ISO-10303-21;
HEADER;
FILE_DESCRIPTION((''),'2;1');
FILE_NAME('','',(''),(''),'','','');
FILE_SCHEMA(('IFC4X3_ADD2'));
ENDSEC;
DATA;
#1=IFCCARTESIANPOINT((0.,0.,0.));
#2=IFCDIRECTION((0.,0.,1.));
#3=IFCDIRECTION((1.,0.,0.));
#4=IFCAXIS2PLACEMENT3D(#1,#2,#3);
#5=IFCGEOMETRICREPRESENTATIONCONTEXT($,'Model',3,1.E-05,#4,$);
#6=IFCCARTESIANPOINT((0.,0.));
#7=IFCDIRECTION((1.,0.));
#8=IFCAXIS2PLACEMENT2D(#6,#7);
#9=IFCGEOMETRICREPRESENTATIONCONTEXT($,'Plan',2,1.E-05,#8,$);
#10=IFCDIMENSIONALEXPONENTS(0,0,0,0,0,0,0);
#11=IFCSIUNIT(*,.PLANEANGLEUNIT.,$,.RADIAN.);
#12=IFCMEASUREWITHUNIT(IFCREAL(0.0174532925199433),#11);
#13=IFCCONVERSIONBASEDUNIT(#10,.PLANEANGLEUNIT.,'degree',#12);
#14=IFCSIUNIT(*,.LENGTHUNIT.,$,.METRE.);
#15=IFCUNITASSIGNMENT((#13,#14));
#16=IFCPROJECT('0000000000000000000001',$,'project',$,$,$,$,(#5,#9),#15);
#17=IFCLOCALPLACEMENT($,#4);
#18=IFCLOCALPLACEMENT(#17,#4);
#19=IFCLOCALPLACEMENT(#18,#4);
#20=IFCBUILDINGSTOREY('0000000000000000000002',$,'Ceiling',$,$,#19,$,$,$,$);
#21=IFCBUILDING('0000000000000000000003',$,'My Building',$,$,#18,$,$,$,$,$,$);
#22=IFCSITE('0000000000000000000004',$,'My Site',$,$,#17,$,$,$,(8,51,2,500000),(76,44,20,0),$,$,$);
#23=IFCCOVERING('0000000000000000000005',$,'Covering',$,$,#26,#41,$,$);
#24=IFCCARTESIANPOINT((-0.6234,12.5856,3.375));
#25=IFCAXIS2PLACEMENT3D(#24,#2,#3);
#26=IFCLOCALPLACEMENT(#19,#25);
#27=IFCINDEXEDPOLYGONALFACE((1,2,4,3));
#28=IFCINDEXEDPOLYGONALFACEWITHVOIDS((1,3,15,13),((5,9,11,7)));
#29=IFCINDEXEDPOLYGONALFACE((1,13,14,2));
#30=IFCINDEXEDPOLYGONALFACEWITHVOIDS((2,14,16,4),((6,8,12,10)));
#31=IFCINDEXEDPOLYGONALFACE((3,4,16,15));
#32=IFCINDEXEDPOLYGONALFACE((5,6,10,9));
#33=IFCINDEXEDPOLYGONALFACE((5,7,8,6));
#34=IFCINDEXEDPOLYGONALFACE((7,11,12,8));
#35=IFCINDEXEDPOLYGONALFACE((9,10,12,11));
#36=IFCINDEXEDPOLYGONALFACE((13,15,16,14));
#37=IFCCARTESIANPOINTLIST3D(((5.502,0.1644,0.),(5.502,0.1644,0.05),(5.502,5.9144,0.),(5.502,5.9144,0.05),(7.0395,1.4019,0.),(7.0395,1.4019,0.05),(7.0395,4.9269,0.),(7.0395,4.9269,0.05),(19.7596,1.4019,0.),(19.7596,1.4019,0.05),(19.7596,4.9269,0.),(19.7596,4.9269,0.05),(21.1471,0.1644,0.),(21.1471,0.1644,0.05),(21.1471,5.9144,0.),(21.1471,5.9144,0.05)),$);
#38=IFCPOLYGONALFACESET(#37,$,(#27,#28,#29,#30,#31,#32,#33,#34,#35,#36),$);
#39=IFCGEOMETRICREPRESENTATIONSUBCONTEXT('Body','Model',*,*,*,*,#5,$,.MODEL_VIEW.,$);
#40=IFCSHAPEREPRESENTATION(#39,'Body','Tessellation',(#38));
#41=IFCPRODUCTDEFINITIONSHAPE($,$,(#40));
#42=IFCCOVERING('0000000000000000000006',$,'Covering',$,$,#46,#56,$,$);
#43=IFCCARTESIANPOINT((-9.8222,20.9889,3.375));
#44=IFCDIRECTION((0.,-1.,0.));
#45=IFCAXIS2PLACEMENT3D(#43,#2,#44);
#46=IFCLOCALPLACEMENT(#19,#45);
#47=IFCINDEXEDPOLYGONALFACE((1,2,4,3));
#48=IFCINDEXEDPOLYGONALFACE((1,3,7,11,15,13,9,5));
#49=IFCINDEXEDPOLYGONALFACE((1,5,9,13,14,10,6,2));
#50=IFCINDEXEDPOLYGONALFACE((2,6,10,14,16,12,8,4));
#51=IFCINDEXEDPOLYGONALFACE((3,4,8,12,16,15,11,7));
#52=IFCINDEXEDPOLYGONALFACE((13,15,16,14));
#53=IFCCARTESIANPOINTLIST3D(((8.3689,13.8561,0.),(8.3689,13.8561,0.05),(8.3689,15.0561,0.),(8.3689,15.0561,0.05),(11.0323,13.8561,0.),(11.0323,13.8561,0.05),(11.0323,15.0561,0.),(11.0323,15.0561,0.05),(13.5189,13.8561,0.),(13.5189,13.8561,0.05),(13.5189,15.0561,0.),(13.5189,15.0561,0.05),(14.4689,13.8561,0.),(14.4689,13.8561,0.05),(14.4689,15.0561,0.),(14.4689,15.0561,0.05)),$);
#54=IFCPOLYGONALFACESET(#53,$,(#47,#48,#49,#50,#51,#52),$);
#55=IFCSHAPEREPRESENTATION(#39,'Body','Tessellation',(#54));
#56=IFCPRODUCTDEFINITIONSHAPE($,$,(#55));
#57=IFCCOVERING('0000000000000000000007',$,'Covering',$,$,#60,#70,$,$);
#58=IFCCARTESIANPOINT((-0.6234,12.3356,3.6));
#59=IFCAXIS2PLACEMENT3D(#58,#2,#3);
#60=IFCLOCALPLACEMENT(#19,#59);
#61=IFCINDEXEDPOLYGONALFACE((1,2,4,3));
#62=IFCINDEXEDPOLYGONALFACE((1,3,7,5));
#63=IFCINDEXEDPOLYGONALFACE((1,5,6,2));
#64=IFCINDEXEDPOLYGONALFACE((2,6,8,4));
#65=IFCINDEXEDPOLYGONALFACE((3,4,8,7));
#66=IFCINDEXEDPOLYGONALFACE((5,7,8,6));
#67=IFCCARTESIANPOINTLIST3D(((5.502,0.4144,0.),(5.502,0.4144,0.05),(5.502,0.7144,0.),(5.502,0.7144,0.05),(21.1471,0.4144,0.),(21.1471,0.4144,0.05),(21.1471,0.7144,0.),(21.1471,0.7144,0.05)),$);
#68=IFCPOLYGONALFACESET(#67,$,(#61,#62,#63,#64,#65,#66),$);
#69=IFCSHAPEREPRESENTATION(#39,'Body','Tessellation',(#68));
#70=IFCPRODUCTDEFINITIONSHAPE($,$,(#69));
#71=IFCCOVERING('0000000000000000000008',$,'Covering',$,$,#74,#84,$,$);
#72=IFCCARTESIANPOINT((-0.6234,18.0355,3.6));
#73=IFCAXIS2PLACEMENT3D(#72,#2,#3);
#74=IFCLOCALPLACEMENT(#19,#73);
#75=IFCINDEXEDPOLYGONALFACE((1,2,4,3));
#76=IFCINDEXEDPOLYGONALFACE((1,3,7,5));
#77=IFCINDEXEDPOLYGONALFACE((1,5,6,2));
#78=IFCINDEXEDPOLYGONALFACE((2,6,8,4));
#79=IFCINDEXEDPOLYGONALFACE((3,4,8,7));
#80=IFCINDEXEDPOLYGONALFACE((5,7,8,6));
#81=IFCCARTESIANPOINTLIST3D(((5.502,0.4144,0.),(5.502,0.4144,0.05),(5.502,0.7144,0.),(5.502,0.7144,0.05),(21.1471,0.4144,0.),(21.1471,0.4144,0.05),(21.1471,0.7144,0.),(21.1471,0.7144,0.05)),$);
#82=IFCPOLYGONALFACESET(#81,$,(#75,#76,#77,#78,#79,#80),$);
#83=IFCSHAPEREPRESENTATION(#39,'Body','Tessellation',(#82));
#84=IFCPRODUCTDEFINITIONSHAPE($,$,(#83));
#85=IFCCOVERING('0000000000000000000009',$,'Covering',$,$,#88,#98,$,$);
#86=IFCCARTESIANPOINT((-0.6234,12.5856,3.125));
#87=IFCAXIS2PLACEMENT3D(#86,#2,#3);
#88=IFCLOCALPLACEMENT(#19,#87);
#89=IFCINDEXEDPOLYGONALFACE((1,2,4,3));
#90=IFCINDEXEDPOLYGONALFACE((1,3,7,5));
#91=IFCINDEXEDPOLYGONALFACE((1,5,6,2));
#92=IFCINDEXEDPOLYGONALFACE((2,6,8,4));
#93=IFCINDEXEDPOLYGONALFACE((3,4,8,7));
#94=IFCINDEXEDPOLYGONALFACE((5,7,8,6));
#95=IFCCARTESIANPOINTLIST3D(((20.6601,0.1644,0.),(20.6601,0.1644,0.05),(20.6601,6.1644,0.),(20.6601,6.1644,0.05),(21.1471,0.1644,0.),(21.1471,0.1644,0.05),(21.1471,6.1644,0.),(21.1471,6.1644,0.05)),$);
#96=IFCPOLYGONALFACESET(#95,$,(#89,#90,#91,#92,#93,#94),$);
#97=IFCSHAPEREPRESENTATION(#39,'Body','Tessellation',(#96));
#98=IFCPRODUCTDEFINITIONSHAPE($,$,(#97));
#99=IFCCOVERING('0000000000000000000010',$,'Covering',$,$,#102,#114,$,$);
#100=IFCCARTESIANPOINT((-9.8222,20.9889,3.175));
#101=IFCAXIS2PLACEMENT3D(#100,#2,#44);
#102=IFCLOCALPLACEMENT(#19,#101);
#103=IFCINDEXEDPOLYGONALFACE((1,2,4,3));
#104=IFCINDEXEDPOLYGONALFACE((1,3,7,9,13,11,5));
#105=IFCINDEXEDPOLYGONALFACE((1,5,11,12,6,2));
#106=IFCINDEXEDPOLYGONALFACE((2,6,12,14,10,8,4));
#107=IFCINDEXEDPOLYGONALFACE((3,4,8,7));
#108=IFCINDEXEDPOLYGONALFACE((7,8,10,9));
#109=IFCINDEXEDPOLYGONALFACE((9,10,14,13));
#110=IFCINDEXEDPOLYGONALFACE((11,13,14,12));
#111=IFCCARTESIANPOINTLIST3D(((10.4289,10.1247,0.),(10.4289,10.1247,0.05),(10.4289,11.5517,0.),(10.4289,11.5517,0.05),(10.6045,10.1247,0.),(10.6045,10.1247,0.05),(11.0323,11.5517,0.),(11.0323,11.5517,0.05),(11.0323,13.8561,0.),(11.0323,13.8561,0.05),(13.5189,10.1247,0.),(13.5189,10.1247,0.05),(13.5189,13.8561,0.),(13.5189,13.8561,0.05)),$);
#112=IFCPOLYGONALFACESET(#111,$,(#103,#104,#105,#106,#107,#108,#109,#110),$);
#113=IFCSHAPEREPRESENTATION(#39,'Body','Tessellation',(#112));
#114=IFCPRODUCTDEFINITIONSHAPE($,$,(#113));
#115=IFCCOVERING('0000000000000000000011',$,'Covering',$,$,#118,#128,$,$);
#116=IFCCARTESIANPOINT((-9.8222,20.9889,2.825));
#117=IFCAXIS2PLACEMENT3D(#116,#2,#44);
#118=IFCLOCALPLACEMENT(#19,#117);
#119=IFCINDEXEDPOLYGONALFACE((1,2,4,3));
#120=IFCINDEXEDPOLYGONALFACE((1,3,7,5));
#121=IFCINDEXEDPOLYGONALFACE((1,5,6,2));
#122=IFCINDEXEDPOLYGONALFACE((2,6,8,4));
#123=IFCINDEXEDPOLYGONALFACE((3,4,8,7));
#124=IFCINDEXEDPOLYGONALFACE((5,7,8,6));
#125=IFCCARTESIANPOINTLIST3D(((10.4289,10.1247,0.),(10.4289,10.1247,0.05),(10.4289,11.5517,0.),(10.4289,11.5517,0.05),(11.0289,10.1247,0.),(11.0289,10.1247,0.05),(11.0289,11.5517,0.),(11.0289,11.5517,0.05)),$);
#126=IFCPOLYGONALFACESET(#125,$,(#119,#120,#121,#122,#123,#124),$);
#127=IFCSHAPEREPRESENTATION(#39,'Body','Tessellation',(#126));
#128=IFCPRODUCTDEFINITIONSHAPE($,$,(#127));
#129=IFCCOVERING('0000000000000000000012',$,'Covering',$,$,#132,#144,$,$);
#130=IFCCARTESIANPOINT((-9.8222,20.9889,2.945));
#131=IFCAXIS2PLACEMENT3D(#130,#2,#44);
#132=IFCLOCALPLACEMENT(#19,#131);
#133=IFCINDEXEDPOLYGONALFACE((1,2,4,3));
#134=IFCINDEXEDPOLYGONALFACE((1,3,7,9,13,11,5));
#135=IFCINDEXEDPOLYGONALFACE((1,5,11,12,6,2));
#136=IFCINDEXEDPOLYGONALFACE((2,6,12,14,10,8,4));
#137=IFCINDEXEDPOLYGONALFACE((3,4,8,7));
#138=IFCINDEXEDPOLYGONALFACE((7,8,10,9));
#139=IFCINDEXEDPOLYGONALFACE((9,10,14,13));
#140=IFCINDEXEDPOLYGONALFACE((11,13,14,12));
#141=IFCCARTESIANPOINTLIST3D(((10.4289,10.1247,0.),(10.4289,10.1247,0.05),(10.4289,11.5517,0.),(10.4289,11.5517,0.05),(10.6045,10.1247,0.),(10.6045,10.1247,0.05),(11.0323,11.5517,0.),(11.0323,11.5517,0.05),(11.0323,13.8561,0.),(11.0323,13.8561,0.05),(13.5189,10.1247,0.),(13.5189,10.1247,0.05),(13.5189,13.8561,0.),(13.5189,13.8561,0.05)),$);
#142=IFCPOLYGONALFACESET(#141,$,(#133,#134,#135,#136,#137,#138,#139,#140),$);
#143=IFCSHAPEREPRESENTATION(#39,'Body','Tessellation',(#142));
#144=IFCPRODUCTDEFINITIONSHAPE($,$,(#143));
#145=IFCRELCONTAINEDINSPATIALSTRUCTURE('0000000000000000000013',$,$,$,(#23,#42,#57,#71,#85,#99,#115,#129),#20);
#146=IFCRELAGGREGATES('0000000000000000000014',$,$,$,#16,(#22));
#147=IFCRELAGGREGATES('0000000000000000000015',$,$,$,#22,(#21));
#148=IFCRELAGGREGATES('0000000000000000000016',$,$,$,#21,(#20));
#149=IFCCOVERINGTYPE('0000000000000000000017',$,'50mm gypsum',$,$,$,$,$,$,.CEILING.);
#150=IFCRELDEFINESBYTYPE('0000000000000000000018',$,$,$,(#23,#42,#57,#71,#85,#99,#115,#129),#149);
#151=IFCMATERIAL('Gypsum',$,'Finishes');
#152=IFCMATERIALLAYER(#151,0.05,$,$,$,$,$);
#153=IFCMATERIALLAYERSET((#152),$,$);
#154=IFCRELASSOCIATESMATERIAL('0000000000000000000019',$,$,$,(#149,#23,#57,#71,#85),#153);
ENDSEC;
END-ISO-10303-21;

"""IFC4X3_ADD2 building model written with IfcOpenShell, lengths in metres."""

from ifc_helpers import new_model, entity, si_unit, converted_unit, frame, origin_with_axes, origin_2d_with_axis, place, context, subcontext, project, spatial, indexed_curve, outline, extrude, material, layer, layer_set, layer_usage, type_object, element, save


model = new_model("IFC4X3_ADD2")

# Units and contexts
model_context = context("Model", 3, precision=1e-05, world=origin_with_axes())
plan_context = context("Plan", 2, precision=1e-05, world=origin_2d_with_axis())
body_context = subcontext(model_context, "Body", "Model", "MODEL_VIEW")
ifc_project = project(units=[converted_unit("PLANEANGLEUNIT", "degree", entity("IfcReal", 0.0174532925199433), si_unit("PLANEANGLEUNIT", "RADIAN"), dimensions=[0, 0, 0, 0, 0, 0, 0]), si_unit("LENGTHUNIT", "METRE")], contexts=[model_context, plan_context])

# Site, building, storey
site_placement = place(None, origin_with_axes())
site = spatial("IfcSite", under=ifc_project, at=site_placement, Name="My Site", RefLatitude=(8, 51, 2, 500000), RefLongitude=(76, 44, 20, 0))
building_placement = place(site_placement, origin_with_axes())
building = spatial("IfcBuilding", under=site, at=building_placement, Name="My Building")
storey_placement = place(building_placement, origin_with_axes())
storey = spatial("IfcBuildingStorey", under=building, at=storey_placement, Name="Ceiling")

# Coverings
ifc_material_1 = material(Name="Gypsum", Category="Finishes")
ifc_layer_1 = layer(ifc_material_1, 0.05)
ifc_layer_set_1 = layer_set([ifc_layer_1])
ifc_layer_usage_1 = layer_usage(ifc_layer_set_1, "AXIS3", "POSITIVE", 0.0)
covering_type_1 = type_object("IfcCoveringType", Name="50mm gypsum", PredefinedType="CEILING", material=ifc_layer_set_1)
covering_1_placement = place(storey_placement, frame((-0.6234, 12.5856, 3.375), z_axis=(0.0, 0.0, 1.0), x_axis=(1.0, 0.0, 0.0)))
element("IfcCovering", 1, at=covering_1_placement, inside=storey, type_object=covering_type_1, material=ifc_layer_usage_1, Name="Covering", context=body_context, shape_type="SweptSolid", body=[
    extrude(outline(indexed_curve([(21.1471, 5.9144), (5.502, 5.9144), (5.502, 0.1644), (21.1471, 0.1644), (21.1471, 5.9144)]), holes=[indexed_curve([(19.7596, 4.9269), (19.7596, 1.4019), (7.0395, 1.4019), (7.0395, 4.9269), (19.7596, 4.9269)])]), None, (0.0, 0.0, 1.0), 0.05),
])
covering_2_placement = place(storey_placement, frame((-9.8222, 20.9889, 3.375), z_axis=(0.0, 0.0, 1.0), x_axis=(0.0, -1.0, 0.0)))
element("IfcCovering", 2, at=covering_2_placement, inside=storey, type_object=covering_type_1, Name="Covering", context=body_context, shape_type="SweptSolid", body=[
    extrude(outline(indexed_curve([(13.5189, 13.8561), (14.4689, 13.8561), (14.4689, 15.0561), (13.5189, 15.0561), (11.0323, 15.0561), (8.3689, 15.0561), (8.3689, 13.8561), (11.0323, 13.8561), (13.5189, 13.8561)])), None, (0.0, 0.0, 1.0), 0.05),
])
ifc_layer_usage_2 = layer_usage(ifc_layer_set_1, "AXIS3", "POSITIVE", 0.0)
covering_3_placement = place(storey_placement, frame((-0.6234, 12.3356, 3.6), z_axis=(0.0, 0.0, 1.0), x_axis=(1.0, 0.0, 0.0)))
element("IfcCovering", 3, at=covering_3_placement, inside=storey, type_object=covering_type_1, material=ifc_layer_usage_2, Name="Covering", context=body_context, shape_type="SweptSolid", body=[
    extrude(outline(indexed_curve([(5.502, 0.7144), (21.1471, 0.7144), (21.1471, 0.4144), (5.502, 0.4144), (5.502, 0.7144)])), None, (0.0, 0.0, 1.0), 0.05),
])
ifc_layer_usage_3 = layer_usage(ifc_layer_set_1, "AXIS3", "POSITIVE", 0.0)
covering_4_placement = place(storey_placement, frame((-0.6234, 18.0355, 3.6), z_axis=(0.0, 0.0, 1.0), x_axis=(1.0, 0.0, 0.0)))
element("IfcCovering", 4, at=covering_4_placement, inside=storey, type_object=covering_type_1, material=ifc_layer_usage_3, Name="Covering", context=body_context, shape_type="SweptSolid", body=[
    extrude(outline(indexed_curve([(5.502, 0.7144), (21.1471, 0.7144), (21.1471, 0.4144), (5.502, 0.4144), (5.502, 0.7144)])), None, (0.0, 0.0, 1.0), 0.05),
])
ifc_layer_usage_4 = layer_usage(ifc_layer_set_1, "AXIS3", "POSITIVE", 0.0)
covering_5_placement = place(storey_placement, frame((-0.6234, 12.5856, 3.125), z_axis=(0.0, 0.0, 1.0), x_axis=(1.0, 0.0, 0.0)))
element("IfcCovering", 5, at=covering_5_placement, inside=storey, type_object=covering_type_1, material=ifc_layer_usage_4, Name="Covering", context=body_context, shape_type="SweptSolid", body=[
    extrude(outline(indexed_curve([(20.6601, 0.1644), (20.6601, 6.1644), (21.1471, 6.1644), (21.1471, 0.1644), (20.6601, 0.1644)])), None, (0.0, 0.0, 1.0), 0.05),
])
covering_6_placement = place(storey_placement, frame((-9.8222, 20.9889, 3.175), z_axis=(0.0, 0.0, 1.0), x_axis=(0.0, -1.0, 0.0)))
element("IfcCovering", 6, at=covering_6_placement, inside=storey, type_object=covering_type_1, Name="Covering", context=body_context, shape_type="SweptSolid", body=[
    extrude(outline(indexed_curve([(10.6045, 10.1247), (10.4289, 10.1247), (10.4289, 11.5517), (11.0323, 11.5517), (11.0323, 13.8561), (13.5189, 13.8561), (13.5189, 10.1247), (10.6045, 10.1247)])), None, (0.0, 0.0, 1.0), 0.05),
])
covering_7_placement = place(storey_placement, frame((-9.8222, 20.9889, 2.825), z_axis=(0.0, 0.0, 1.0), x_axis=(0.0, -1.0, 0.0)))
element("IfcCovering", 7, at=covering_7_placement, inside=storey, type_object=covering_type_1, Name="Covering", context=body_context, shape_type="SweptSolid", body=[
    extrude(outline(indexed_curve([(11.0289, 11.5517), (10.4289, 11.5517), (10.4289, 10.1247), (11.0289, 10.1247), (11.0289, 11.5517)])), None, (0.0, 0.0, 1.0), 0.05),
])
covering_8_placement = place(storey_placement, frame((-9.8222, 20.9889, 2.945), z_axis=(0.0, 0.0, 1.0), x_axis=(0.0, -1.0, 0.0)))
element("IfcCovering", 8, at=covering_8_placement, inside=storey, type_object=covering_type_1, Name="Covering", context=body_context, shape_type="SweptSolid", body=[
    extrude(outline(indexed_curve([(10.6045, 10.1247), (10.4289, 10.1247), (10.4289, 11.5517), (11.0323, 11.5517), (11.0323, 13.8561), (13.5189, 13.8561), (13.5189, 10.1247), (10.6045, 10.1247)])), None, (0.0, 0.0, 1.0), 0.05),
])

save(model, "model.ifc")
